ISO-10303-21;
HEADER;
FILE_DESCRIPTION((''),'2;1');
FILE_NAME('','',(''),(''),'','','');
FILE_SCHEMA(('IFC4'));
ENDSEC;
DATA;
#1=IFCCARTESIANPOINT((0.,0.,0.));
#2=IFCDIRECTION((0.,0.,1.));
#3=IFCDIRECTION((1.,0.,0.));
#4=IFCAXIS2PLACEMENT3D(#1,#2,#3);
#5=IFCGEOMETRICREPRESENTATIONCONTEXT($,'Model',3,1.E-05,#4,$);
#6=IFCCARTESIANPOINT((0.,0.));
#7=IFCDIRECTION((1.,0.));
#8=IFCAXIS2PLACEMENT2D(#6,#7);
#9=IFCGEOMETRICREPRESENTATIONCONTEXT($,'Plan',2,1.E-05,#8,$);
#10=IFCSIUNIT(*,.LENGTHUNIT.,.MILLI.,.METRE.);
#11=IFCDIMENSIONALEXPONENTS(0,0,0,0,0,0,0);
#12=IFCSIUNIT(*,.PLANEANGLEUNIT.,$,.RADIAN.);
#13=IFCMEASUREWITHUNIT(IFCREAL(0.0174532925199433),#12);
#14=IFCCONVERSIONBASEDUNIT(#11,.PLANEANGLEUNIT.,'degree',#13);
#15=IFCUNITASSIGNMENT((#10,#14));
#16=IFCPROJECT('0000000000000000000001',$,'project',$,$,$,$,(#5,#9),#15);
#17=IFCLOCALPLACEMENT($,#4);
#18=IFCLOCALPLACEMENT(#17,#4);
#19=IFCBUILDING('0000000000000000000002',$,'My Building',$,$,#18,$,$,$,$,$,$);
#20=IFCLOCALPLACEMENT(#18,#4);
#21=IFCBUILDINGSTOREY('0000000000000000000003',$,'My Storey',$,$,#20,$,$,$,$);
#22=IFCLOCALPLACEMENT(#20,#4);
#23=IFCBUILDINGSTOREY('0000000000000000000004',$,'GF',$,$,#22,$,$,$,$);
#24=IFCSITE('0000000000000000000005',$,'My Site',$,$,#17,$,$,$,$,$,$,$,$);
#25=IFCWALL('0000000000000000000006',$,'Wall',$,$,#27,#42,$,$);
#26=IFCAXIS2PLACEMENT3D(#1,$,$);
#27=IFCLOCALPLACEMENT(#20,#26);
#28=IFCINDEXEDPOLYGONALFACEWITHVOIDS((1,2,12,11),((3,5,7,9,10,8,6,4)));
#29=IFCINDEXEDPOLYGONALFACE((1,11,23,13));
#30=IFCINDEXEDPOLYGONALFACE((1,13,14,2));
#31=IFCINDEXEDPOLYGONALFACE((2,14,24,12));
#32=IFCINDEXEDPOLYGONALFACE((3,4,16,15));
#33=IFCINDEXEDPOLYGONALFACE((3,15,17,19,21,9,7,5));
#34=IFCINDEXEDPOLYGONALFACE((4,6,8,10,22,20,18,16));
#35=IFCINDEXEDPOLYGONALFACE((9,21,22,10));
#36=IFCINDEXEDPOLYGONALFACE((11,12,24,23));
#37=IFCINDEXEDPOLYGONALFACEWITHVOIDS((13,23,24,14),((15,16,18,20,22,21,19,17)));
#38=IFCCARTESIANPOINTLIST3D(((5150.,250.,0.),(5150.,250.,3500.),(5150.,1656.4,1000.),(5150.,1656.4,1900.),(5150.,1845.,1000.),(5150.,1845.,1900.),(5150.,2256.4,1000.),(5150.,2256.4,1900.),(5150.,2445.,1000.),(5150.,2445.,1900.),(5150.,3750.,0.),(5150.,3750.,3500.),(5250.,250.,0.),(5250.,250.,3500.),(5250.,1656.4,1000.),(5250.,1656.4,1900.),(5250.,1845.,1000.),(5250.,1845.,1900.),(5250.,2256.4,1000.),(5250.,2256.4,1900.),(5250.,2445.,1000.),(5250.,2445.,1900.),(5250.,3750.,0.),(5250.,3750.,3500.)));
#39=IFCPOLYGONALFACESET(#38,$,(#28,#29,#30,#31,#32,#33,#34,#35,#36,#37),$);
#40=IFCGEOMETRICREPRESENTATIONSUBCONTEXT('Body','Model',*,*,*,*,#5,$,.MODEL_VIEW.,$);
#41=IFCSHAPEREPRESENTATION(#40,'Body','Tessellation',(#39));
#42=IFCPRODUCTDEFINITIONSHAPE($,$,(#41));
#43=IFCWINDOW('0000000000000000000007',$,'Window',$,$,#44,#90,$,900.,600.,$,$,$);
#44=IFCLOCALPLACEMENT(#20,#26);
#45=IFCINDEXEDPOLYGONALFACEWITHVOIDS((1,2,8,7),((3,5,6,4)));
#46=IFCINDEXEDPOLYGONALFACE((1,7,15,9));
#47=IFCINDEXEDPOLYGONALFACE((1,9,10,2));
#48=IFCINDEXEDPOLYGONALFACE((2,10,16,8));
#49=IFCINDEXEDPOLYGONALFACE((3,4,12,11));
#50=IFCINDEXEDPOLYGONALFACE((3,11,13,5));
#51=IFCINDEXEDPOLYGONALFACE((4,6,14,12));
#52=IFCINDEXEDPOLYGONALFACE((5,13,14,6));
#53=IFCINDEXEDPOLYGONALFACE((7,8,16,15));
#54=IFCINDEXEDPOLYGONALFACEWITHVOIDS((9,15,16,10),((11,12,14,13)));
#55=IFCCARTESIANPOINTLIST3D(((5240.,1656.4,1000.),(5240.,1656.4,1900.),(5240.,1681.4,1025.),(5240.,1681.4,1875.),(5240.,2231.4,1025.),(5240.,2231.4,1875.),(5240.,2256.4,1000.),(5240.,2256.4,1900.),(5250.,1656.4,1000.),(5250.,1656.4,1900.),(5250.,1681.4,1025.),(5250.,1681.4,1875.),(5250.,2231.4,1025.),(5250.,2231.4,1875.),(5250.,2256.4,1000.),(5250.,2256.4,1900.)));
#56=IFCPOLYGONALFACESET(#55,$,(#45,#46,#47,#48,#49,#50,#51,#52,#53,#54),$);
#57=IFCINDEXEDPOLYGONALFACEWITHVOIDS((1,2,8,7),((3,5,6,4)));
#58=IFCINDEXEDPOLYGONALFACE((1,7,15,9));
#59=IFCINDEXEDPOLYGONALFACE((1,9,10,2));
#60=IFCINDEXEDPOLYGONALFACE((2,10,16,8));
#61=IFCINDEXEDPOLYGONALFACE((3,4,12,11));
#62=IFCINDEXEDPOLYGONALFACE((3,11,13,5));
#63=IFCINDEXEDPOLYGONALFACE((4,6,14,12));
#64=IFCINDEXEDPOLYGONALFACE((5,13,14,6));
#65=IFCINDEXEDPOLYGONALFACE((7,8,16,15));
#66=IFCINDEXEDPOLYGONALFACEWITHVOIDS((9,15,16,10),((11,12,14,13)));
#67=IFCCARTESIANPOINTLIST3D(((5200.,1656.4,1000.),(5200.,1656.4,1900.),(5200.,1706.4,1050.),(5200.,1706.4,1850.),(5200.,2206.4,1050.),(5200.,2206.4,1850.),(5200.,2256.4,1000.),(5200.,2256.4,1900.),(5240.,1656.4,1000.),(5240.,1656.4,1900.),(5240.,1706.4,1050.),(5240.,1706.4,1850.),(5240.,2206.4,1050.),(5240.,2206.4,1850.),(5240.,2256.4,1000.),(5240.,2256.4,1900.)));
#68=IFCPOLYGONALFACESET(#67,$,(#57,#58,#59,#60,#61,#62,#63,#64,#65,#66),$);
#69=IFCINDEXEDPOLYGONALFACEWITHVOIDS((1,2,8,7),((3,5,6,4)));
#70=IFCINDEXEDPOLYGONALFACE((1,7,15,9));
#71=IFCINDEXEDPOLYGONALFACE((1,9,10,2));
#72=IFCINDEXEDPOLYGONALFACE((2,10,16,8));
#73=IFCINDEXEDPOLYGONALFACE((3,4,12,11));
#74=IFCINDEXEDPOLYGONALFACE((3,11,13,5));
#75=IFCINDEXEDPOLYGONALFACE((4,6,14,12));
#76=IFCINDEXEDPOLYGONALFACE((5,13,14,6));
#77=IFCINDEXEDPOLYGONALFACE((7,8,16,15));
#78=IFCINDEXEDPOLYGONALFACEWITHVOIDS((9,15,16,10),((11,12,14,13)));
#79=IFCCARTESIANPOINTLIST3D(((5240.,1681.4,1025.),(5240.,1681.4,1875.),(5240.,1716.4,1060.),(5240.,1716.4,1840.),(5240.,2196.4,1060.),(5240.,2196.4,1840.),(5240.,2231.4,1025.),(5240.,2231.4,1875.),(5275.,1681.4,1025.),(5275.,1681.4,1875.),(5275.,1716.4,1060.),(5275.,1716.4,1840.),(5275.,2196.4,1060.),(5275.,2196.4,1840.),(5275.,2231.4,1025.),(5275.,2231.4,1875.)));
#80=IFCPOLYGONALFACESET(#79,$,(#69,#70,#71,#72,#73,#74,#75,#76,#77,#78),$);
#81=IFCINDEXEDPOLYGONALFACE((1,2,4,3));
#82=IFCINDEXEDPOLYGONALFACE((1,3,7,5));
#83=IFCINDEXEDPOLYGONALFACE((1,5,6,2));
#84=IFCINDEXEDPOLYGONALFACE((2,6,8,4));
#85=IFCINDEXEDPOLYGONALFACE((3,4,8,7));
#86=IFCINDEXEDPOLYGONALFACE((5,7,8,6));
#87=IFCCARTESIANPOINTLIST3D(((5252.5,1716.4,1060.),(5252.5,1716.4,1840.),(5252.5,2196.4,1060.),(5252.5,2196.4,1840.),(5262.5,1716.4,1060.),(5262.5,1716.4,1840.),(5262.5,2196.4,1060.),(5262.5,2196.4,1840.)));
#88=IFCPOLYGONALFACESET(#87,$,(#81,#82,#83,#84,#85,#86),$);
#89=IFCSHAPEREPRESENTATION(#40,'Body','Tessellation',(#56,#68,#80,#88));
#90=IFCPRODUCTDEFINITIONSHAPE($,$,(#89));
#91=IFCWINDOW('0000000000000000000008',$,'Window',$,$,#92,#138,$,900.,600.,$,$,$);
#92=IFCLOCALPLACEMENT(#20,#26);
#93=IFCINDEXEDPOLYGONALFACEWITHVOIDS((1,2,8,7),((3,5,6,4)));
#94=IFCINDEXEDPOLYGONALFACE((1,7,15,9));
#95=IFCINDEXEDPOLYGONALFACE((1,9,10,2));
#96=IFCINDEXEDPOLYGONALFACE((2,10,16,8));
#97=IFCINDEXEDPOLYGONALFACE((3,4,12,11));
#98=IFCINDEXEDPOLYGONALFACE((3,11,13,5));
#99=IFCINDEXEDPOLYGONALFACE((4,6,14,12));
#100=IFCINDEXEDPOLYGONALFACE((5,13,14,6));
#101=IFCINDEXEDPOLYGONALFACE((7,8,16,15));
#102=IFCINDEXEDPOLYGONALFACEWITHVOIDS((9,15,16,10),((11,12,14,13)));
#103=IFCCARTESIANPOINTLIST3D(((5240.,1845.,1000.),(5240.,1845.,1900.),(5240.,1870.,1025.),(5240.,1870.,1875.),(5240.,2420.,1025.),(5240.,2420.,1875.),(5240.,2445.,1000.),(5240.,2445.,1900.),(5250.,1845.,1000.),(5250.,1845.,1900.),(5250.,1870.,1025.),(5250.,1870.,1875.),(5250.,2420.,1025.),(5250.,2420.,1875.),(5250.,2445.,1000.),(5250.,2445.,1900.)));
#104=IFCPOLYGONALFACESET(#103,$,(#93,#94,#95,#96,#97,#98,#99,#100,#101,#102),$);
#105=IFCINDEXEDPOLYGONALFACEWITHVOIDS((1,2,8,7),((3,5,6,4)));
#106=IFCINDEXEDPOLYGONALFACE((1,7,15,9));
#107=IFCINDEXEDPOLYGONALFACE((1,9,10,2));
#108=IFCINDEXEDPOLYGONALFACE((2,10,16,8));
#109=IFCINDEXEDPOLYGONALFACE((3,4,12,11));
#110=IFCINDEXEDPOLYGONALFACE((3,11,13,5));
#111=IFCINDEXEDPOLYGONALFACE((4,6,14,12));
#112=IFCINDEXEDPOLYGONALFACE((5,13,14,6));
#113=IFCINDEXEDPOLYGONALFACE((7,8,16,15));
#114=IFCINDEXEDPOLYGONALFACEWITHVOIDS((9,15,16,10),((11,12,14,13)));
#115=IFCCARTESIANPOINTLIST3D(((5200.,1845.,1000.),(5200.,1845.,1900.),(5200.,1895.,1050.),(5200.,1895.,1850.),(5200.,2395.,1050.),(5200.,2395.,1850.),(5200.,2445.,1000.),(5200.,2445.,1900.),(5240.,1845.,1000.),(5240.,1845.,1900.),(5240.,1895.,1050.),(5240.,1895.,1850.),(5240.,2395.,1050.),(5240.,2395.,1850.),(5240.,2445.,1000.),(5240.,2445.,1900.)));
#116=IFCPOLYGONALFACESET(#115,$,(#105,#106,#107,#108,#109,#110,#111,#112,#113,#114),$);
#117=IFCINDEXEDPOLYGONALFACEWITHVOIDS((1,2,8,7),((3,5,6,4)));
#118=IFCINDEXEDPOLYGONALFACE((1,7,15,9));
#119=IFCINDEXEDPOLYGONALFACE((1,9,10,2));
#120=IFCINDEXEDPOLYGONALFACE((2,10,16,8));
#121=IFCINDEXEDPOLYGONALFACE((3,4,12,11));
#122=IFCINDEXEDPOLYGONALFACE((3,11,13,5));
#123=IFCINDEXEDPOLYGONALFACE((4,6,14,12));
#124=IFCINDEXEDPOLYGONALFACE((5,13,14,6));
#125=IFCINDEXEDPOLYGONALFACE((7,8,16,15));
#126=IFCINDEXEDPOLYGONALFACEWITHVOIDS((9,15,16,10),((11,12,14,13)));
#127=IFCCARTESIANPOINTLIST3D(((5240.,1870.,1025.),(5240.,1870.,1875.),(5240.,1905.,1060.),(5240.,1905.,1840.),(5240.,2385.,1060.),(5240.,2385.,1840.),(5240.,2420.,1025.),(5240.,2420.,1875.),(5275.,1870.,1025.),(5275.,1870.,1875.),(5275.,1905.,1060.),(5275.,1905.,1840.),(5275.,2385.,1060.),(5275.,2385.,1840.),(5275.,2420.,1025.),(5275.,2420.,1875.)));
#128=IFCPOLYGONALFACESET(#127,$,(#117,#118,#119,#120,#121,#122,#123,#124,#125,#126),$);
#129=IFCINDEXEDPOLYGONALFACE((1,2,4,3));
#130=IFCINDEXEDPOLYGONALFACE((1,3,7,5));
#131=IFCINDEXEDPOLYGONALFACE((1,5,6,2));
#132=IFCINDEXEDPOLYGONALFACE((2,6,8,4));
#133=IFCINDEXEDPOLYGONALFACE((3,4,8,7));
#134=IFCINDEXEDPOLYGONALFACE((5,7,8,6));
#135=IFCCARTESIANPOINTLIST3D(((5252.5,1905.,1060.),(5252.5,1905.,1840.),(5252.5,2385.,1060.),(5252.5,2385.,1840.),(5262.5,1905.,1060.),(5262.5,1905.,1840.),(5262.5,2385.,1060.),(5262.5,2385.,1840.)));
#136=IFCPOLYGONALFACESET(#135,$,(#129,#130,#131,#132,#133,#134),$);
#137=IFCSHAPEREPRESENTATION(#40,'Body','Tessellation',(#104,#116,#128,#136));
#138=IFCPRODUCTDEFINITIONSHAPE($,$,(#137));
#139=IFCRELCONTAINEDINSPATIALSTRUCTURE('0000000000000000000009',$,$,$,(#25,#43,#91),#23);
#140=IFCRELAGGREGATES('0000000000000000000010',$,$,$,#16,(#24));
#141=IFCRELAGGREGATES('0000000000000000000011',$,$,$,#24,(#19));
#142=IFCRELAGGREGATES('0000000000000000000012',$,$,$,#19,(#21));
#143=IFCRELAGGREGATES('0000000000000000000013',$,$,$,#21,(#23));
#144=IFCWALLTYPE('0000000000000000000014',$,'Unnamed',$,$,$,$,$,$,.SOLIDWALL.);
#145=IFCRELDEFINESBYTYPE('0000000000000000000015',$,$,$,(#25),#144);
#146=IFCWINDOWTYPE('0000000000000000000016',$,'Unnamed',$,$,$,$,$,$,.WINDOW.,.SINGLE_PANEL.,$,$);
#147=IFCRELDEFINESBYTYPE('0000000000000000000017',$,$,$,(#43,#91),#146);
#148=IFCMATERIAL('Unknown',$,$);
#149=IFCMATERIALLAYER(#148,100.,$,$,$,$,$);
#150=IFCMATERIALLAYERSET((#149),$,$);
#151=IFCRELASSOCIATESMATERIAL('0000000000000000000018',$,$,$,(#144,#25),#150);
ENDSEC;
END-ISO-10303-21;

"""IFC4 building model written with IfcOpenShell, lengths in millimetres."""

from ifc_helpers import new_model, entity, si_unit, converted_unit, frame, origin_with_axes, origin_2d_with_axis, place, context, subcontext, project, spatial, line, indexed_curve, outline, extrude, shape, source, transform, mapped, material, layer, layer_set, layer_usage, type_object, type_shapes, element, fill, save


model = new_model("IFC4")

# Units and contexts
model_context = context("Model", 3, precision=1e-05, world=origin_with_axes())
plan_context = context("Plan", 2, precision=1e-05, world=origin_2d_with_axis())
body_context_1 = subcontext(model_context, "Body", "Model", "MODEL_VIEW")
body_context_2 = subcontext(plan_context, "Body", "Plan", "PLAN_VIEW")
ifc_project = project(units=[si_unit("LENGTHUNIT", "METRE", prefix="MILLI"), converted_unit("PLANEANGLEUNIT", "degree", entity("IfcReal", 0.0174532925199433), si_unit("PLANEANGLEUNIT", "RADIAN"), dimensions=[0, 0, 0, 0, 0, 0, 0])], contexts=[model_context, plan_context])

# Site, building, storeys
site_placement = place(None, origin_with_axes())
site = spatial("IfcSite", under=ifc_project, at=site_placement, Name="My Site")
building_placement = place(site_placement, origin_with_axes())
building = spatial("IfcBuilding", under=site, at=building_placement, Name="My Building")
storey_1_placement = place(building_placement, origin_with_axes())
storey_1 = spatial("IfcBuildingStorey", under=building, at=storey_1_placement, Name="My Storey")
storey_2_placement = place(storey_1_placement, origin_with_axes())
storey_2 = spatial("IfcBuildingStorey", under=storey_1, at=storey_2_placement, Name="GF")

# Shared definitions
ifc_material = material(Name="Unknown")
ifc_layer_1 = layer(ifc_material, 100.0)
ifc_layer_set_1 = layer_set([ifc_layer_1])
wall_type_1 = type_object("IfcWallType", Name="Unnamed", PredefinedType="SOLIDWALL", material=ifc_layer_set_1)

# Shared definitions
shared_shape_1 = source(origin_with_axes(), body_context_1, "Body", "SweptSolid", [
    extrude(outline(indexed_curve([(0.0, 0.0), (600.0, 0.0), (600.0, 900.0), (0.0, 900.0)], segments=[line(1, 2, 3, 4, 1)])), frame((0.0, -600.0, 0.0), z_axis=(0.0, -1.0, 0.0), x_axis=(1.0, 0.0, 0.0)), (0.0, 0.0, -1.0), 1200.0),
])
window_type = type_object("IfcWindowType", Name="Unnamed", PartitioningType="SINGLE_PANEL", PredefinedType="WINDOW")
shared_shape_2 = source(origin_with_axes(), body_context_1, "Body", "SweptSolid", [
    extrude(outline(indexed_curve([(0.0, 0.0), (600.0, 0.0), (600.0, 900.0), (0.0, 900.0)], segments=[line(1, 2, 3, 4, 1)]), holes=[indexed_curve([(25.0, 25.0), (575.0, 25.0), (575.0, 875.0), (25.0, 875.0)], segments=[line(1, 2, 3, 4, 1)])]), frame((0.0, 90.0, 0.0), z_axis=(0.0, -1.0, 0.0), x_axis=(1.0, 0.0, 0.0)), (0.0, 0.0, -1.0), 10.0),
    extrude(outline(indexed_curve([(0.0, 0.0), (600.0, 0.0), (600.0, 900.0), (0.0, 900.0)], segments=[line(1, 2, 3, 4, 1)]), holes=[indexed_curve([(50.0, 50.0), (550.0, 50.0), (550.0, 850.0), (50.0, 850.0)], segments=[line(1, 2, 3, 4, 1)])]), frame((0.0, 50.0, 0.0), z_axis=(0.0, -1.0, 0.0), x_axis=(1.0, 0.0, 0.0)), (0.0, 0.0, -1.0), 40.0),
    extrude(outline(indexed_curve([(0.0, 0.0), (550.0, 0.0), (550.0, 850.0), (0.0, 850.0)], segments=[line(1, 2, 3, 4, 1)]), holes=[indexed_curve([(35.0, 35.0), (515.0, 35.0), (515.0, 815.0), (35.0, 815.0)], segments=[line(1, 2, 3, 4, 1)])]), frame((25.0, 90.0, 25.0), z_axis=(0.0, -1.0, 0.0), x_axis=(1.0, 0.0, 0.0)), (0.0, 0.0, -1.0), 35.0),
    extrude(outline(indexed_curve([(35.0, 35.0), (515.0, 35.0), (515.0, 815.0), (35.0, 815.0)], segments=[line(1, 2, 3, 4, 1)])), frame((25.0, 102.5, 25.0), z_axis=(0.0, -1.0, 0.0), x_axis=(1.0, 0.0, 0.0)), (0.0, 0.0, -1.0), 10.0),
])
shared_shape_3 = source(origin_with_axes(), body_context_2, "Body", "Curve2D", [
    entity("IfcIndexedPolyCurve", entity("IfcCartesianPointList2D", [[50.0, 50.0], [550.0, 50.0]])),
    entity("IfcIndexedPolyCurve", entity("IfcCartesianPointList2D", [[0.0, 100.0], [25.0, 100.0], [25.0, 90.0], [50.0, 90.0], [50.0, 50.0], [0.0, 50.0]]), [entity("IfcLineIndex", [1, 2, 3, 4, 5, 6, 1])]),
    entity("IfcIndexedPolyCurve", entity("IfcCartesianPointList2D", [[600.0, 100.0], [575.0, 100.0], [575.0, 90.0], [550.0, 90.0], [550.0, 50.0], [600.0, 50.0]]), [entity("IfcLineIndex", [1, 2, 3, 4, 5, 6, 1])]),
    entity("IfcIndexedPolyCurve", entity("IfcCartesianPointList2D", [[25.0, 90.0], [60.0, 90.0], [60.0, 125.0], [25.0, 125.0]]), [entity("IfcLineIndex", [1, 2, 3, 4, 1])]),
    entity("IfcIndexedPolyCurve", entity("IfcCartesianPointList2D", [[575.0, 90.0], [540.0, 90.0], [540.0, 125.0], [575.0, 125.0]]), [entity("IfcLineIndex", [1, 2, 3, 4, 1])]),
    entity("IfcIndexedPolyCurve", entity("IfcCartesianPointList2D", [[60.0, 90.0], [540.0, 90.0]])),
    entity("IfcIndexedPolyCurve", entity("IfcCartesianPointList2D", [[60.0, 125.0], [540.0, 125.0]])),
    entity("IfcIndexedPolyCurve", entity("IfcCartesianPointList2D", [[60.0, 107.5], [540.0, 107.5]])),
])
type_shapes(window_type, [shared_shape_2, shared_shape_3])

# Wall, openings, windows
ifc_layer_usage_1 = layer_usage(ifc_layer_set_1, "AXIS2", "POSITIVE", 0.0)
wall_1_placement = place(storey_2_placement, frame((5150.0, 3750.0, 0.0), z_axis=(0.0, 0.0, 1.0), x_axis=(0.0, -1.0, 0.0)))
wall_1 = element("IfcWall", 1, at=wall_1_placement, inside=storey_2, type_object=wall_type_1, material=ifc_layer_usage_1, Name="Wall", context=body_context_1, shape_type="SweptSolid", body=[
    extrude(outline(indexed_curve([(0.0, 0.0), (0.0, 100.0), (3500.0, 100.0), (3500.0, 0.0)], segments=[line(1, 2, 3, 4, 1)])), origin_with_axes(), (0.0, 0.0, 1.0), 3500.0),
])
opening_1_placement = place(wall_1_placement, frame((1493.6, 0.0, 1000.0), z_axis=(0.0, 0.0, 1.0), x_axis=(1.0, 0.0, 0.0)))
opening_1 = element("IfcOpeningElement", 2, at=opening_1_placement, cuts=wall_1, PredefinedType="OPENING", context=body_context_1, shape_type="MappedRepresentation", body=[
    mapped(shared_shape_1, transform((0.0, 0.0, 0.0), x_axis=(1.0, 0.0, 0.0), y_axis=(0.0, 1.0, 0.0), z_axis=(0.0, 0.0, 1.0), scale=1.0)),
])
opening_2_placement = place(wall_1_placement, frame((1305.0, 0.0, 1000.0), z_axis=(0.0, 0.0, 1.0), x_axis=(1.0, 0.0, 0.0)))
opening_2 = element("IfcOpeningElement", 3, at=opening_2_placement, cuts=wall_1, PredefinedType="OPENING", context=body_context_1, shape_type="MappedRepresentation", body=[
    mapped(shared_shape_1, transform((0.0, 0.0, 0.0), x_axis=(1.0, 0.0, 0.0), y_axis=(0.0, 1.0, 0.0), z_axis=(0.0, 0.0, 1.0), scale=1.0)),
])
window_1_placement = place(opening_1_placement, origin_with_axes())
window_1 = element("IfcWindow", 4, at=window_1_placement, inside=storey_2, type_object=window_type, Name="Window", OverallHeight=900.0, OverallWidth=600.0, shapes=[
    shape(body_context_1, "Body", "MappedRepresentation", [mapped(shared_shape_2, transform((0.0, 0.0, 0.0), x_axis=(1.0, 0.0, 0.0), y_axis=(0.0, 1.0, 0.0), z_axis=(0.0, 0.0, 1.0), scale=1.0))]),
    shape(body_context_2, "Body", "MappedRepresentation", [mapped(shared_shape_3, transform((0.0, 0.0, 0.0), x_axis=(1.0, 0.0, 0.0), y_axis=(0.0, 1.0, 0.0), z_axis=(0.0, 0.0, 1.0), scale=1.0))]),
])
fill(opening_1, window_1)
window_2_placement = place(opening_2_placement, frame((0.0, 0.0, 0.0), z_axis=(0.0, 0.0, 1.0), x_axis=(1.0, 0.0, 0.0)))
window_2 = element("IfcWindow", 5, at=window_2_placement, inside=storey_2, type_object=window_type, Name="Window", OverallHeight=900.0, OverallWidth=600.0, shapes=[
    shape(body_context_1, "Body", "MappedRepresentation", [mapped(shared_shape_2, transform((0.0, 0.0, 0.0), x_axis=(1.0, 0.0, 0.0), y_axis=(0.0, 1.0, 0.0), z_axis=(0.0, 0.0, 1.0), scale=1.0))]),
    shape(body_context_2, "Body", "MappedRepresentation", [mapped(shared_shape_3, transform((0.0, 0.0, 0.0), x_axis=(1.0, 0.0, 0.0), y_axis=(0.0, 1.0, 0.0), z_axis=(0.0, 0.0, 1.0), scale=1.0))]),
])
fill(opening_2, window_2)

save(model, "model.ifc")
